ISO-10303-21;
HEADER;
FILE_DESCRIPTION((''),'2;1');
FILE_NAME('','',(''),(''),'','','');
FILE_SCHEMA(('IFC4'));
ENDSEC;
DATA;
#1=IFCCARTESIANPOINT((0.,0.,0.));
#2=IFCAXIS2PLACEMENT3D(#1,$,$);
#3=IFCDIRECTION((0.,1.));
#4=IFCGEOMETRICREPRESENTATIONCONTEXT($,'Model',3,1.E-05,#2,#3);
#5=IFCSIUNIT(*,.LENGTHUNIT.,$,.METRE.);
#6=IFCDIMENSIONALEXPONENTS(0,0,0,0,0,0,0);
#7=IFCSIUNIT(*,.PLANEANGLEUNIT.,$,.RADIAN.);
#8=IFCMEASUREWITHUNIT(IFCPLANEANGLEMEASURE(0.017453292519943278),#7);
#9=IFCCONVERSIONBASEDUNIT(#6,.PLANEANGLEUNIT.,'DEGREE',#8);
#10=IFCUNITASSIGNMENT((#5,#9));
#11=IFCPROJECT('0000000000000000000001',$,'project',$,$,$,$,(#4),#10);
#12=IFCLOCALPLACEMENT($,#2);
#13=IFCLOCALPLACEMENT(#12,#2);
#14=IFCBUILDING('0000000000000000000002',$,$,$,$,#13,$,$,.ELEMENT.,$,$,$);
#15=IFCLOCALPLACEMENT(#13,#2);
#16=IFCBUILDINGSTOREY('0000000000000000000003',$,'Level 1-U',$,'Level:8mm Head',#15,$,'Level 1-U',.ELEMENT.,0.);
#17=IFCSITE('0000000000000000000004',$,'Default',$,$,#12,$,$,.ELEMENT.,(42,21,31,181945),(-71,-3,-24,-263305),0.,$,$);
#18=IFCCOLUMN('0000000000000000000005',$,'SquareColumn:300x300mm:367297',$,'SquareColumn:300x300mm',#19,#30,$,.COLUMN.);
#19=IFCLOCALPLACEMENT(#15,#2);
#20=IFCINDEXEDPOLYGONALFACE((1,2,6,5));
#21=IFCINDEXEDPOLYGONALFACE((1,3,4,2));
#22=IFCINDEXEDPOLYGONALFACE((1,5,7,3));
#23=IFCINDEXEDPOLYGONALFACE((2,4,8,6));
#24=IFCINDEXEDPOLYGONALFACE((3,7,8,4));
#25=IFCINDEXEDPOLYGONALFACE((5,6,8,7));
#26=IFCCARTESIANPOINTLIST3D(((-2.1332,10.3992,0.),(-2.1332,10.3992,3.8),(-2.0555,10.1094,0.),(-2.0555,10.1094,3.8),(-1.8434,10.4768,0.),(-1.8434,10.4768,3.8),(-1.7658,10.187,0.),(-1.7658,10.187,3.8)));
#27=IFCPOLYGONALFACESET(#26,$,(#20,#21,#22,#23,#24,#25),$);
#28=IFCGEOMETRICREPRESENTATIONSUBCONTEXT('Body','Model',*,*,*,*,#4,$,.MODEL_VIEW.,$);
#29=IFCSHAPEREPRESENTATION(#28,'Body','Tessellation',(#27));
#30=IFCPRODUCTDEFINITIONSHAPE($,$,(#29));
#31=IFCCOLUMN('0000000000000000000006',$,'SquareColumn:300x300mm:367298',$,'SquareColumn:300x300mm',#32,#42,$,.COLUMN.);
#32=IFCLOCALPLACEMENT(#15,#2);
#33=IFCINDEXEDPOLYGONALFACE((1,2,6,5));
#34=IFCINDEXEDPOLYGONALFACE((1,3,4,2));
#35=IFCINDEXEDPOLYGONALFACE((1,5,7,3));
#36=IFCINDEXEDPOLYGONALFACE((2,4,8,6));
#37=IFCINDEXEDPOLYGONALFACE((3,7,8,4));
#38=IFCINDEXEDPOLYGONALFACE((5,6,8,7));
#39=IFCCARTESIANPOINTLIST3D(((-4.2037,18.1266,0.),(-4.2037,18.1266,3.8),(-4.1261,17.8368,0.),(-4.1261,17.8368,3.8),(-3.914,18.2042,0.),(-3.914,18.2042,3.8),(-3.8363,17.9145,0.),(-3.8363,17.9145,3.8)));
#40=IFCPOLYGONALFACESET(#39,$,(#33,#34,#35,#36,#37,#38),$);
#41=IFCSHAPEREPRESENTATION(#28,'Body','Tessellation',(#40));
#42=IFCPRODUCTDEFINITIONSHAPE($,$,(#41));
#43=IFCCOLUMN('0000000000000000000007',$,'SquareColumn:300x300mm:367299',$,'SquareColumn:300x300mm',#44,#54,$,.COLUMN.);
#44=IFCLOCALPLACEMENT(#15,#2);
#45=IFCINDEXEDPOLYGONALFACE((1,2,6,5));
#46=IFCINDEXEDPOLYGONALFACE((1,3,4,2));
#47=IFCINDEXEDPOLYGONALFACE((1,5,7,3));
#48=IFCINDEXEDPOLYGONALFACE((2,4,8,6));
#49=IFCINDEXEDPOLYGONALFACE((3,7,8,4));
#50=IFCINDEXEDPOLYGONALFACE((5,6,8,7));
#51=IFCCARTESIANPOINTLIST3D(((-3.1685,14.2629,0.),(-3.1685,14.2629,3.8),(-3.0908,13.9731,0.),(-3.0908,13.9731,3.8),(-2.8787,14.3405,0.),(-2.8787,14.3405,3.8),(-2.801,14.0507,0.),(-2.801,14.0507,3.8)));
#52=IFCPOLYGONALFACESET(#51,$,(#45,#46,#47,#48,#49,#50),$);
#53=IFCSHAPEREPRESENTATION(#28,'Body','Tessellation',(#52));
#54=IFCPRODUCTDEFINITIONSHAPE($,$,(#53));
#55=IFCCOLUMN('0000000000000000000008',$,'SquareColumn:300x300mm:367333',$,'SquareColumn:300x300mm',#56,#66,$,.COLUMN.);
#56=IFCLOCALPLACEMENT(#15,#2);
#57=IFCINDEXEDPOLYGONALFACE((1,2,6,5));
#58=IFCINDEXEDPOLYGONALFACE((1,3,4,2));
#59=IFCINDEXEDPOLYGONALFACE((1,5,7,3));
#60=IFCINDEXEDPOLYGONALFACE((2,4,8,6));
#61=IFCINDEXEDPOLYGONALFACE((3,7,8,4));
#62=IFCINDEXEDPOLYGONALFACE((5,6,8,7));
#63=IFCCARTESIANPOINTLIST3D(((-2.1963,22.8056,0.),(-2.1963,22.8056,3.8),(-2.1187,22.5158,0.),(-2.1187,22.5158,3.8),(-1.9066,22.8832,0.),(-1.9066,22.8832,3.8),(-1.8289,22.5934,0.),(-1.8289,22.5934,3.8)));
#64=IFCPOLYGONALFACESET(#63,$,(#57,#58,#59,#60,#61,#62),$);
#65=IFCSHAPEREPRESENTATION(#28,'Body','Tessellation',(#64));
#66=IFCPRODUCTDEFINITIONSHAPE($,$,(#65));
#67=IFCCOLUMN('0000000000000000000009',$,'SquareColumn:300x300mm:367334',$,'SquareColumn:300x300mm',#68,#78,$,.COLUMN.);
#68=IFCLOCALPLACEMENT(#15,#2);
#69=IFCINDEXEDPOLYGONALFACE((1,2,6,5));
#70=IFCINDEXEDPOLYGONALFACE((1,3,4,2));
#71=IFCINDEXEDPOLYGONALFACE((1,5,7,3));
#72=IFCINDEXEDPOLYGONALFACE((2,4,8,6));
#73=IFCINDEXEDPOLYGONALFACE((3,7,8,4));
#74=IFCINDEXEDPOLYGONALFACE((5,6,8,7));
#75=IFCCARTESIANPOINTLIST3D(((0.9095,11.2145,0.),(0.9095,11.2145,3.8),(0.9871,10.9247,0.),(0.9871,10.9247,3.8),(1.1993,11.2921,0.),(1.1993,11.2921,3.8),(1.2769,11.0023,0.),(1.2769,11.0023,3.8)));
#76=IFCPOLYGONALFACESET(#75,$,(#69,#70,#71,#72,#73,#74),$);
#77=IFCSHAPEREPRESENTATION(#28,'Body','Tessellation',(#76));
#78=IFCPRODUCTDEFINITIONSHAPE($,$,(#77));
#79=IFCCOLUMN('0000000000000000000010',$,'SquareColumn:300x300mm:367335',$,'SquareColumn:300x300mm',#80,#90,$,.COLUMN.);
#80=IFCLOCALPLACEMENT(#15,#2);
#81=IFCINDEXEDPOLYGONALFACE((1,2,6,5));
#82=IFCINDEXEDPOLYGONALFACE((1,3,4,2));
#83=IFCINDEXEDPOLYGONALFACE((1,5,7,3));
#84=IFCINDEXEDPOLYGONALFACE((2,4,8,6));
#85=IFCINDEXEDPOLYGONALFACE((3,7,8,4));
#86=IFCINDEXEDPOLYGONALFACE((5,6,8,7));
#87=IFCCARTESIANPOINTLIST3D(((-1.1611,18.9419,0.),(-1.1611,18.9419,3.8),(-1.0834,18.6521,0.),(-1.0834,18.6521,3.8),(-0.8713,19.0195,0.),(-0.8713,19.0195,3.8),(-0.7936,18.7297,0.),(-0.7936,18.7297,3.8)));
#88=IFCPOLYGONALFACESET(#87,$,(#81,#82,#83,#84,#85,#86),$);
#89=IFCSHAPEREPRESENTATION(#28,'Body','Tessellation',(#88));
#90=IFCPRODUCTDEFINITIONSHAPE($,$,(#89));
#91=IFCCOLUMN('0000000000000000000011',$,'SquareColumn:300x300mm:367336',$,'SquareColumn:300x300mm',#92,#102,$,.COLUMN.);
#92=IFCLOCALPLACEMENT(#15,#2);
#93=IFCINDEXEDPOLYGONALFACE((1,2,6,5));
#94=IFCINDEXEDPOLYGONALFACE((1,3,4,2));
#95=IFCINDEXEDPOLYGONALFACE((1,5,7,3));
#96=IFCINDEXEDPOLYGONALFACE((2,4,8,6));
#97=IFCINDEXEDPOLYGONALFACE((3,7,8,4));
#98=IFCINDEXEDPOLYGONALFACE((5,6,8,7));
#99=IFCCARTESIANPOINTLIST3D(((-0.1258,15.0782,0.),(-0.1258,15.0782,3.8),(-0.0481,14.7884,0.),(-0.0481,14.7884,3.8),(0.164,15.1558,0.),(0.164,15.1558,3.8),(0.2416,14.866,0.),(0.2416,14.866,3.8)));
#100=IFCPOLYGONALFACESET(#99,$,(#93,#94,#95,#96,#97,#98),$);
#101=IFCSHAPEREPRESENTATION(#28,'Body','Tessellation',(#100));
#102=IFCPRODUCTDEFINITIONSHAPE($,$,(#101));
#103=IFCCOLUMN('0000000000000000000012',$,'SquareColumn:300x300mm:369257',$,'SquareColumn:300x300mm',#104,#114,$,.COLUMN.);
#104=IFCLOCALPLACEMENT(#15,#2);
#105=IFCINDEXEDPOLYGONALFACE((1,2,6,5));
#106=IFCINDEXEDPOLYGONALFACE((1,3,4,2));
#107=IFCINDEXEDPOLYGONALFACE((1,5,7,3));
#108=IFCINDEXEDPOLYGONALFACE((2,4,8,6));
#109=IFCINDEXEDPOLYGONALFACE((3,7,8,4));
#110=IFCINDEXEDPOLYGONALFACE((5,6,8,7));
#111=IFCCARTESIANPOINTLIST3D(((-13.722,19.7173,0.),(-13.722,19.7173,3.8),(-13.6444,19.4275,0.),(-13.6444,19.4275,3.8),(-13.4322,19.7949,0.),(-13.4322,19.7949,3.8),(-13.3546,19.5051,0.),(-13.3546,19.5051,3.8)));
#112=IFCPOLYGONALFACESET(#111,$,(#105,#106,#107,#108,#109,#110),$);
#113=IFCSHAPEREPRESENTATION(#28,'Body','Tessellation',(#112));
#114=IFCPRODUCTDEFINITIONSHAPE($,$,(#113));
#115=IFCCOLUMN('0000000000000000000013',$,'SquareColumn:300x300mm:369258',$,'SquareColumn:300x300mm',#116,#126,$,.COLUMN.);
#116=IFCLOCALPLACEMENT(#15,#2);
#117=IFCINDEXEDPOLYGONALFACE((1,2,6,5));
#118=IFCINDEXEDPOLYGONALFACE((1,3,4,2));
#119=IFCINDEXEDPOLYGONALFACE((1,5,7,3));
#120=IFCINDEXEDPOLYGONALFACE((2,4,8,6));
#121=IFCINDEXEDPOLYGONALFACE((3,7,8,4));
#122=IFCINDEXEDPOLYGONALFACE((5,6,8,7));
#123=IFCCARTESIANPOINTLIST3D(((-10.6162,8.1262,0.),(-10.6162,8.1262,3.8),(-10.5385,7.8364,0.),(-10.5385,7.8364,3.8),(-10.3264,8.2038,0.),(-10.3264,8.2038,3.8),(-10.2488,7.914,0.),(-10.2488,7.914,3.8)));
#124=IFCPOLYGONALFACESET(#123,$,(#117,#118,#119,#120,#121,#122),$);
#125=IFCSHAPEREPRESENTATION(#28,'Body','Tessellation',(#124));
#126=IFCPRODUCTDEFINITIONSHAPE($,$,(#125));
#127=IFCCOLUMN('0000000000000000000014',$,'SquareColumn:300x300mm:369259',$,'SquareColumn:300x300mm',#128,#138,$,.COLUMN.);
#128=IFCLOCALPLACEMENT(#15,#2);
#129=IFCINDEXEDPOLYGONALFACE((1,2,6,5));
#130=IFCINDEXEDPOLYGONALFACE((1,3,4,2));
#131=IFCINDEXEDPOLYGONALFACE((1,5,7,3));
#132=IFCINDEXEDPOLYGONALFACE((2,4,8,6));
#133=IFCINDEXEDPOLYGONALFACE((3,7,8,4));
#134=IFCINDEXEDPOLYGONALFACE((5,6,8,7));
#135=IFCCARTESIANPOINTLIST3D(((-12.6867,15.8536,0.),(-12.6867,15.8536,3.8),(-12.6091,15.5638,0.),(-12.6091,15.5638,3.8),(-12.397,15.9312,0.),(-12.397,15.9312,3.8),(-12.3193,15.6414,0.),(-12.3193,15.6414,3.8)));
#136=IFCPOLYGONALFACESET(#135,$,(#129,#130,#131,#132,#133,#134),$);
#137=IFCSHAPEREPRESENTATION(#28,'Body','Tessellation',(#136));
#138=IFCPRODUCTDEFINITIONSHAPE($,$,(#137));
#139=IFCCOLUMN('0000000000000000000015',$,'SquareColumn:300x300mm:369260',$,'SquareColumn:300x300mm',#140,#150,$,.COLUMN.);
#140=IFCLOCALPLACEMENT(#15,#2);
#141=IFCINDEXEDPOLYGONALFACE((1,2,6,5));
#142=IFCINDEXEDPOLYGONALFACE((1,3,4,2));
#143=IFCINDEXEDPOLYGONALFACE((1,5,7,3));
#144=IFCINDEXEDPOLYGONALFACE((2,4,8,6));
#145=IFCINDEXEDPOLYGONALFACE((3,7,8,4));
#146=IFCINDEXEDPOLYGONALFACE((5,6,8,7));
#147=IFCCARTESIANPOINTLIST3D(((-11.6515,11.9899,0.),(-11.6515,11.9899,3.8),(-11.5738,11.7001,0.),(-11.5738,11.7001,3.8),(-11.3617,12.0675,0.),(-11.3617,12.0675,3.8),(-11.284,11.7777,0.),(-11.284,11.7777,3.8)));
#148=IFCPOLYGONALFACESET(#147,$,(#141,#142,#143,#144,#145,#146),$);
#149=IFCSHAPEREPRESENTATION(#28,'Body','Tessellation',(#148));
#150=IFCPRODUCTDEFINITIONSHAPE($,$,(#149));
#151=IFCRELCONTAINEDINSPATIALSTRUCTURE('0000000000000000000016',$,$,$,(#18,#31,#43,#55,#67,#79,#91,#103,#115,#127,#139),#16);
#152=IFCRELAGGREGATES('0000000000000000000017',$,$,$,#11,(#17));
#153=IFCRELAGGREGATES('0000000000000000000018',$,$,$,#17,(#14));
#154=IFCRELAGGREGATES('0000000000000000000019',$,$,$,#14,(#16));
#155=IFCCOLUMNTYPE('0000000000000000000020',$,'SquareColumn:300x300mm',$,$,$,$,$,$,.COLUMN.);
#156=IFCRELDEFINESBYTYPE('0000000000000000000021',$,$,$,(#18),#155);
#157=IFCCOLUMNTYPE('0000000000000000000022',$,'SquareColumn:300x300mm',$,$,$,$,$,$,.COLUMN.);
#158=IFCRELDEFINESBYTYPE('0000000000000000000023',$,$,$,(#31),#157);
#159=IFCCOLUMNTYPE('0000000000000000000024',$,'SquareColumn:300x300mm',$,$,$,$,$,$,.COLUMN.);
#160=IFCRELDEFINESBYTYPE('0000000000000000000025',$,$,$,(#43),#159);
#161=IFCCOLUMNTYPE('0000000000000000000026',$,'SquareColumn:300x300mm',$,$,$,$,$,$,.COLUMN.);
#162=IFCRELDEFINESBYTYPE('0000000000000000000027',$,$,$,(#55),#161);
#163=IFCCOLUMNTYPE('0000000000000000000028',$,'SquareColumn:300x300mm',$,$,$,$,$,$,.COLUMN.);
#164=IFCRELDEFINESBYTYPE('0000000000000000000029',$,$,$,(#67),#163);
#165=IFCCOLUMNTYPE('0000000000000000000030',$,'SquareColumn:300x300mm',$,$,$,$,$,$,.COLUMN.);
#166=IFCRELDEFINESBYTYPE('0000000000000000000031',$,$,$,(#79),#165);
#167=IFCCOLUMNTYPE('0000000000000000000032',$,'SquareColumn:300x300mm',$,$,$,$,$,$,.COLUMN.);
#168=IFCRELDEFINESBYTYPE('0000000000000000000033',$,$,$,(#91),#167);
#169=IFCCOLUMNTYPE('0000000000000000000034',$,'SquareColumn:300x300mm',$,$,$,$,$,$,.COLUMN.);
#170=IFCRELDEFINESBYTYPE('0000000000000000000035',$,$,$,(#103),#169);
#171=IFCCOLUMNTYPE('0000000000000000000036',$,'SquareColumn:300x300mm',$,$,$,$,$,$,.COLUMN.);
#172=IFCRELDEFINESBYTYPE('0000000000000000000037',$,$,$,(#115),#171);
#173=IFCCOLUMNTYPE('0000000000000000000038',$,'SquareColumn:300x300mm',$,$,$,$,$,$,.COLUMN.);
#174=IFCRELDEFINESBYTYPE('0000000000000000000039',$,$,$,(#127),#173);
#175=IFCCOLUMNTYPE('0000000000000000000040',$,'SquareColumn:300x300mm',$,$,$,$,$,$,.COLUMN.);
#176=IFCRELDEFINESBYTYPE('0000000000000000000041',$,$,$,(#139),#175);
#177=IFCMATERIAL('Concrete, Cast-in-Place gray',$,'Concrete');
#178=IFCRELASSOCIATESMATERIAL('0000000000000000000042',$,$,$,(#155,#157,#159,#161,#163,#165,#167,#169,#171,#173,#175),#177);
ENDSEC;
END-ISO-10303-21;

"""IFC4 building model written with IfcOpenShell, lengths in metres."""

from ifc_helpers import new_model, entity, si_unit, converted_unit, direction, frame, frame_2d, origin, origin_2d_with_axis, place, context, subcontext, project, spatial, rectangle, extrude, source, transform, mapped, material, material_profile, profile_set, type_object, type_shapes, element, save


model = new_model("IFC4")

# Units and contexts
model_context = context("Model", 3, precision=1e-05, world=origin(), true_north=direction((0.0, 1.0)))
body_context = subcontext(model_context, "Body", "Model", "MODEL_VIEW")
ifc_project = project(units=[si_unit("LENGTHUNIT", "METRE"), converted_unit("PLANEANGLEUNIT", "DEGREE", entity("IfcPlaneAngleMeasure", 0.017453292519943278), si_unit("PLANEANGLEUNIT", "RADIAN"), dimensions=[0, 0, 0, 0, 0, 0, 0])], contexts=[model_context])

# Site, building, storey
site_placement = place(None, origin())
site = spatial("IfcSite", under=ifc_project, at=site_placement, Name="Default", CompositionType="ELEMENT", RefLatitude=(42, 21, 31, 181945), RefLongitude=(-71, -3, -24, -263305), RefElevation=0.0)
building_placement = place(site_placement, origin())
building = spatial("IfcBuilding", under=site, at=building_placement, CompositionType="ELEMENT")
storey_placement = place(building_placement, origin())
storey = spatial("IfcBuildingStorey", under=building, at=storey_placement, Name="Level 1-U", ObjectType="Level:8mm Head", LongName="Level 1-U", CompositionType="ELEMENT", Elevation=0.0)

# Columns
ifc_material_1 = material(Name="Concrete, Cast-in-Place gray", Category="Concrete")
ifc_material_profile = material_profile(ifc_material_1, rectangle(XDim=0.3, YDim=0.3, at=origin_2d_with_axis()), Name="300x300mm")
ifc_profile_set = profile_set([ifc_material_profile], Name="300x300mm")
column_type_1 = type_object("IfcColumnType", Name="SquareColumn:300x300mm", PredefinedType="COLUMN", material=ifc_profile_set)
shared_shape_1 = source(origin(), body_context, "Body", "SweptSolid", [
    extrude(rectangle(XDim=0.3, YDim=0.3, at=frame_2d((0.0, 0.0), x_axis=(1.0, 0.0))), frame((-1.9495, 10.2931, 0.0), z_axis=(0.0, 0.0, 1.0), x_axis=(-0.258819, 0.965926, 0.0)), (0.0, 0.0, 1.0), 3.8),
])
type_shapes(column_type_1, [shared_shape_1])
column_1_placement = place(storey_placement, origin())
element("IfcColumn", 1, at=column_1_placement, inside=storey, type_object=column_type_1, Name="SquareColumn:300x300mm:367297", ObjectType="SquareColumn:300x300mm", PredefinedType="COLUMN", context=body_context, shape_type="MappedRepresentation", body=[
    mapped(shared_shape_1, transform((0.0, 0.0, 0.0), scale=1.0)),
])
column_type_2 = type_object("IfcColumnType", Name="SquareColumn:300x300mm", PredefinedType="COLUMN", material=ifc_profile_set)
shared_shape_2 = source(origin(), body_context, "Body", "SweptSolid", [
    extrude(rectangle(XDim=0.3, YDim=0.3, at=origin_2d_with_axis()), frame((-4.02, 18.0205, 0.0), z_axis=(0.0, 0.0, 1.0), x_axis=(-0.258819, 0.965926, 0.0)), (0.0, 0.0, 1.0), 3.8),
])
type_shapes(column_type_2, [shared_shape_2])
column_2_placement = place(storey_placement, origin())
element("IfcColumn", 2, at=column_2_placement, inside=storey, type_object=column_type_2, Name="SquareColumn:300x300mm:367298", ObjectType="SquareColumn:300x300mm", PredefinedType="COLUMN", context=body_context, shape_type="MappedRepresentation", body=[
    mapped(shared_shape_2, transform((0.0, 0.0, 0.0), scale=1.0)),
])
column_type_3 = type_object("IfcColumnType", Name="SquareColumn:300x300mm", PredefinedType="COLUMN", material=ifc_profile_set)
shared_shape_3 = source(origin(), body_context, "Body", "SweptSolid", [
    extrude(rectangle(XDim=0.3, YDim=0.3, at=origin_2d_with_axis()), frame((-2.9847, 14.1568, 0.0), z_axis=(0.0, 0.0, 1.0), x_axis=(-0.258819, 0.965926, 0.0)), (0.0, 0.0, 1.0), 3.8),
])
type_shapes(column_type_3, [shared_shape_3])
column_3_placement = place(storey_placement, origin())
element("IfcColumn", 3, at=column_3_placement, inside=storey, type_object=column_type_3, Name="SquareColumn:300x300mm:367299", ObjectType="SquareColumn:300x300mm", PredefinedType="COLUMN", context=body_context, shape_type="MappedRepresentation", body=[
    mapped(shared_shape_3, transform((0.0, 0.0, 0.0), scale=1.0)),
])
column_type_4 = type_object("IfcColumnType", Name="SquareColumn:300x300mm", PredefinedType="COLUMN", material=ifc_profile_set)
shared_shape_4 = source(origin(), body_context, "Body", "SweptSolid", [
    extrude(rectangle(XDim=0.3, YDim=0.3, at=frame_2d((0.0, 0.0), x_axis=(1.0, 0.0))), frame((-2.0126, 22.6995, 0.0), z_axis=(0.0, 0.0, 1.0), x_axis=(-0.258819, 0.965926, 0.0)), (0.0, 0.0, 1.0), 3.8),
])
type_shapes(column_type_4, [shared_shape_4])
column_4_placement = place(storey_placement, origin())
element("IfcColumn", 4, at=column_4_placement, inside=storey, type_object=column_type_4, Name="SquareColumn:300x300mm:367333", ObjectType="SquareColumn:300x300mm", PredefinedType="COLUMN", context=body_context, shape_type="MappedRepresentation", body=[
    mapped(shared_shape_4, transform((0.0, 0.0, 0.0), scale=1.0)),
])
column_type_5 = type_object("IfcColumnType", Name="SquareColumn:300x300mm", PredefinedType="COLUMN", material=ifc_profile_set)
shared_shape_5 = source(origin(), body_context, "Body", "SweptSolid", [
    extrude(rectangle(XDim=0.3, YDim=0.3, at=frame_2d((0.0, 0.0), x_axis=(1.0, 0.0))), frame((1.0932, 11.1084, 0.0), z_axis=(0.0, 0.0, 1.0), x_axis=(-0.258819, 0.965926, 0.0)), (0.0, 0.0, 1.0), 3.8),
])
type_shapes(column_type_5, [shared_shape_5])
column_5_placement = place(storey_placement, origin())
element("IfcColumn", 5, at=column_5_placement, inside=storey, type_object=column_type_5, Name="SquareColumn:300x300mm:367334", ObjectType="SquareColumn:300x300mm", PredefinedType="COLUMN", context=body_context, shape_type="MappedRepresentation", body=[
    mapped(shared_shape_5, transform((0.0, 0.0, 0.0), scale=1.0)),
])
column_type_6 = type_object("IfcColumnType", Name="SquareColumn:300x300mm", PredefinedType="COLUMN", material=ifc_profile_set)
shared_shape_6 = source(origin(), body_context, "Body", "SweptSolid", [
    extrude(rectangle(XDim=0.3, YDim=0.3, at=frame_2d((0.0, 0.0), x_axis=(1.0, 0.0))), frame((-0.9774, 18.8358, 0.0), z_axis=(0.0, 0.0, 1.0), x_axis=(-0.258819, 0.965926, 0.0)), (0.0, 0.0, 1.0), 3.8),
])
type_shapes(column_type_6, [shared_shape_6])
column_6_placement = place(storey_placement, origin())
element("IfcColumn", 6, at=column_6_placement, inside=storey, type_object=column_type_6, Name="SquareColumn:300x300mm:367335", ObjectType="SquareColumn:300x300mm", PredefinedType="COLUMN", context=body_context, shape_type="MappedRepresentation", body=[
    mapped(shared_shape_6, transform((0.0, 0.0, 0.0), scale=1.0)),
])
column_type_7 = type_object("IfcColumnType", Name="SquareColumn:300x300mm", PredefinedType="COLUMN", material=ifc_profile_set)
shared_shape_7 = source(origin(), body_context, "Body", "SweptSolid", [
    extrude(rectangle(XDim=0.3, YDim=0.3, at=origin_2d_with_axis()), frame((0.0579, 14.9721, 0.0), z_axis=(0.0, 0.0, 1.0), x_axis=(-0.258819, 0.965926, 0.0)), (0.0, 0.0, 1.0), 3.8),
])
type_shapes(column_type_7, [shared_shape_7])
column_7_placement = place(storey_placement, origin())
element("IfcColumn", 7, at=column_7_placement, inside=storey, type_object=column_type_7, Name="SquareColumn:300x300mm:367336", ObjectType="SquareColumn:300x300mm", PredefinedType="COLUMN", context=body_context, shape_type="MappedRepresentation", body=[
    mapped(shared_shape_7, transform((0.0, 0.0, 0.0), scale=1.0)),
])
column_type_8 = type_object("IfcColumnType", Name="SquareColumn:300x300mm", PredefinedType="COLUMN", material=ifc_profile_set)
shared_shape_8 = source(origin(), body_context, "Body", "SweptSolid", [
    extrude(rectangle(XDim=0.3, YDim=0.3, at=origin_2d_with_axis()), frame((-13.5383, 19.6112, 0.0), z_axis=(0.0, 0.0, 1.0), x_axis=(-0.258819, 0.965926, 0.0)), (0.0, 0.0, 1.0), 3.8),
])
type_shapes(column_type_8, [shared_shape_8])
column_8_placement = place(storey_placement, origin())
element("IfcColumn", 8, at=column_8_placement, inside=storey, type_object=column_type_8, Name="SquareColumn:300x300mm:369257", ObjectType="SquareColumn:300x300mm", PredefinedType="COLUMN", context=body_context, shape_type="MappedRepresentation", body=[
    mapped(shared_shape_8, transform((0.0, 0.0, 0.0), scale=1.0)),
])
column_type_9 = type_object("IfcColumnType", Name="SquareColumn:300x300mm", PredefinedType="COLUMN", material=ifc_profile_set)
shared_shape_9 = source(origin(), body_context, "Body", "SweptSolid", [
    extrude(rectangle(XDim=0.3, YDim=0.3, at=origin_2d_with_axis()), frame((-10.4325, 8.0201, 0.0), z_axis=(0.0, 0.0, 1.0), x_axis=(-0.258819, 0.965926, 0.0)), (0.0, 0.0, 1.0), 3.8),
])
type_shapes(column_type_9, [shared_shape_9])
column_9_placement = place(storey_placement, origin())
element("IfcColumn", 9, at=column_9_placement, inside=storey, type_object=column_type_9, Name="SquareColumn:300x300mm:369258", ObjectType="SquareColumn:300x300mm", PredefinedType="COLUMN", context=body_context, shape_type="MappedRepresentation", body=[
    mapped(shared_shape_9, transform((0.0, 0.0, 0.0), scale=1.0)),
])
column_type_10 = type_object("IfcColumnType", Name="SquareColumn:300x300mm", PredefinedType="COLUMN", material=ifc_profile_set)
shared_shape_10 = source(origin(), body_context, "Body", "SweptSolid", [
    extrude(rectangle(XDim=0.3, YDim=0.3, at=origin_2d_with_axis()), frame((-12.503, 15.7475, 0.0), z_axis=(0.0, 0.0, 1.0), x_axis=(-0.258819, 0.965926, 0.0)), (0.0, 0.0, 1.0), 3.8),
])
type_shapes(column_type_10, [shared_shape_10])
column_10_placement = place(storey_placement, origin())
element("IfcColumn", 10, at=column_10_placement, inside=storey, type_object=column_type_10, Name="SquareColumn:300x300mm:369259", ObjectType="SquareColumn:300x300mm", PredefinedType="COLUMN", context=body_context, shape_type="MappedRepresentation", body=[
    mapped(shared_shape_10, transform((0.0, 0.0, 0.0), scale=1.0)),
])
column_type_11 = type_object("IfcColumnType", Name="SquareColumn:300x300mm", PredefinedType="COLUMN", material=ifc_profile_set)
shared_shape_11 = source(origin(), body_context, "Body", "SweptSolid", [
    extrude(rectangle(XDim=0.3, YDim=0.3, at=origin_2d_with_axis()), frame((-11.4677, 11.8838, 0.0), z_axis=(0.0, 0.0, 1.0), x_axis=(-0.258819, 0.965926, 0.0)), (0.0, 0.0, 1.0), 3.8),
])
type_shapes(column_type_11, [shared_shape_11])
column_11_placement = place(storey_placement, origin())
element("IfcColumn", 11, at=column_11_placement, inside=storey, type_object=column_type_11, Name="SquareColumn:300x300mm:369260", ObjectType="SquareColumn:300x300mm", PredefinedType="COLUMN", context=body_context, shape_type="MappedRepresentation", body=[
    mapped(shared_shape_11, transform((0.0, 0.0, 0.0), scale=1.0)),
])

save(model, "model.ifc")
